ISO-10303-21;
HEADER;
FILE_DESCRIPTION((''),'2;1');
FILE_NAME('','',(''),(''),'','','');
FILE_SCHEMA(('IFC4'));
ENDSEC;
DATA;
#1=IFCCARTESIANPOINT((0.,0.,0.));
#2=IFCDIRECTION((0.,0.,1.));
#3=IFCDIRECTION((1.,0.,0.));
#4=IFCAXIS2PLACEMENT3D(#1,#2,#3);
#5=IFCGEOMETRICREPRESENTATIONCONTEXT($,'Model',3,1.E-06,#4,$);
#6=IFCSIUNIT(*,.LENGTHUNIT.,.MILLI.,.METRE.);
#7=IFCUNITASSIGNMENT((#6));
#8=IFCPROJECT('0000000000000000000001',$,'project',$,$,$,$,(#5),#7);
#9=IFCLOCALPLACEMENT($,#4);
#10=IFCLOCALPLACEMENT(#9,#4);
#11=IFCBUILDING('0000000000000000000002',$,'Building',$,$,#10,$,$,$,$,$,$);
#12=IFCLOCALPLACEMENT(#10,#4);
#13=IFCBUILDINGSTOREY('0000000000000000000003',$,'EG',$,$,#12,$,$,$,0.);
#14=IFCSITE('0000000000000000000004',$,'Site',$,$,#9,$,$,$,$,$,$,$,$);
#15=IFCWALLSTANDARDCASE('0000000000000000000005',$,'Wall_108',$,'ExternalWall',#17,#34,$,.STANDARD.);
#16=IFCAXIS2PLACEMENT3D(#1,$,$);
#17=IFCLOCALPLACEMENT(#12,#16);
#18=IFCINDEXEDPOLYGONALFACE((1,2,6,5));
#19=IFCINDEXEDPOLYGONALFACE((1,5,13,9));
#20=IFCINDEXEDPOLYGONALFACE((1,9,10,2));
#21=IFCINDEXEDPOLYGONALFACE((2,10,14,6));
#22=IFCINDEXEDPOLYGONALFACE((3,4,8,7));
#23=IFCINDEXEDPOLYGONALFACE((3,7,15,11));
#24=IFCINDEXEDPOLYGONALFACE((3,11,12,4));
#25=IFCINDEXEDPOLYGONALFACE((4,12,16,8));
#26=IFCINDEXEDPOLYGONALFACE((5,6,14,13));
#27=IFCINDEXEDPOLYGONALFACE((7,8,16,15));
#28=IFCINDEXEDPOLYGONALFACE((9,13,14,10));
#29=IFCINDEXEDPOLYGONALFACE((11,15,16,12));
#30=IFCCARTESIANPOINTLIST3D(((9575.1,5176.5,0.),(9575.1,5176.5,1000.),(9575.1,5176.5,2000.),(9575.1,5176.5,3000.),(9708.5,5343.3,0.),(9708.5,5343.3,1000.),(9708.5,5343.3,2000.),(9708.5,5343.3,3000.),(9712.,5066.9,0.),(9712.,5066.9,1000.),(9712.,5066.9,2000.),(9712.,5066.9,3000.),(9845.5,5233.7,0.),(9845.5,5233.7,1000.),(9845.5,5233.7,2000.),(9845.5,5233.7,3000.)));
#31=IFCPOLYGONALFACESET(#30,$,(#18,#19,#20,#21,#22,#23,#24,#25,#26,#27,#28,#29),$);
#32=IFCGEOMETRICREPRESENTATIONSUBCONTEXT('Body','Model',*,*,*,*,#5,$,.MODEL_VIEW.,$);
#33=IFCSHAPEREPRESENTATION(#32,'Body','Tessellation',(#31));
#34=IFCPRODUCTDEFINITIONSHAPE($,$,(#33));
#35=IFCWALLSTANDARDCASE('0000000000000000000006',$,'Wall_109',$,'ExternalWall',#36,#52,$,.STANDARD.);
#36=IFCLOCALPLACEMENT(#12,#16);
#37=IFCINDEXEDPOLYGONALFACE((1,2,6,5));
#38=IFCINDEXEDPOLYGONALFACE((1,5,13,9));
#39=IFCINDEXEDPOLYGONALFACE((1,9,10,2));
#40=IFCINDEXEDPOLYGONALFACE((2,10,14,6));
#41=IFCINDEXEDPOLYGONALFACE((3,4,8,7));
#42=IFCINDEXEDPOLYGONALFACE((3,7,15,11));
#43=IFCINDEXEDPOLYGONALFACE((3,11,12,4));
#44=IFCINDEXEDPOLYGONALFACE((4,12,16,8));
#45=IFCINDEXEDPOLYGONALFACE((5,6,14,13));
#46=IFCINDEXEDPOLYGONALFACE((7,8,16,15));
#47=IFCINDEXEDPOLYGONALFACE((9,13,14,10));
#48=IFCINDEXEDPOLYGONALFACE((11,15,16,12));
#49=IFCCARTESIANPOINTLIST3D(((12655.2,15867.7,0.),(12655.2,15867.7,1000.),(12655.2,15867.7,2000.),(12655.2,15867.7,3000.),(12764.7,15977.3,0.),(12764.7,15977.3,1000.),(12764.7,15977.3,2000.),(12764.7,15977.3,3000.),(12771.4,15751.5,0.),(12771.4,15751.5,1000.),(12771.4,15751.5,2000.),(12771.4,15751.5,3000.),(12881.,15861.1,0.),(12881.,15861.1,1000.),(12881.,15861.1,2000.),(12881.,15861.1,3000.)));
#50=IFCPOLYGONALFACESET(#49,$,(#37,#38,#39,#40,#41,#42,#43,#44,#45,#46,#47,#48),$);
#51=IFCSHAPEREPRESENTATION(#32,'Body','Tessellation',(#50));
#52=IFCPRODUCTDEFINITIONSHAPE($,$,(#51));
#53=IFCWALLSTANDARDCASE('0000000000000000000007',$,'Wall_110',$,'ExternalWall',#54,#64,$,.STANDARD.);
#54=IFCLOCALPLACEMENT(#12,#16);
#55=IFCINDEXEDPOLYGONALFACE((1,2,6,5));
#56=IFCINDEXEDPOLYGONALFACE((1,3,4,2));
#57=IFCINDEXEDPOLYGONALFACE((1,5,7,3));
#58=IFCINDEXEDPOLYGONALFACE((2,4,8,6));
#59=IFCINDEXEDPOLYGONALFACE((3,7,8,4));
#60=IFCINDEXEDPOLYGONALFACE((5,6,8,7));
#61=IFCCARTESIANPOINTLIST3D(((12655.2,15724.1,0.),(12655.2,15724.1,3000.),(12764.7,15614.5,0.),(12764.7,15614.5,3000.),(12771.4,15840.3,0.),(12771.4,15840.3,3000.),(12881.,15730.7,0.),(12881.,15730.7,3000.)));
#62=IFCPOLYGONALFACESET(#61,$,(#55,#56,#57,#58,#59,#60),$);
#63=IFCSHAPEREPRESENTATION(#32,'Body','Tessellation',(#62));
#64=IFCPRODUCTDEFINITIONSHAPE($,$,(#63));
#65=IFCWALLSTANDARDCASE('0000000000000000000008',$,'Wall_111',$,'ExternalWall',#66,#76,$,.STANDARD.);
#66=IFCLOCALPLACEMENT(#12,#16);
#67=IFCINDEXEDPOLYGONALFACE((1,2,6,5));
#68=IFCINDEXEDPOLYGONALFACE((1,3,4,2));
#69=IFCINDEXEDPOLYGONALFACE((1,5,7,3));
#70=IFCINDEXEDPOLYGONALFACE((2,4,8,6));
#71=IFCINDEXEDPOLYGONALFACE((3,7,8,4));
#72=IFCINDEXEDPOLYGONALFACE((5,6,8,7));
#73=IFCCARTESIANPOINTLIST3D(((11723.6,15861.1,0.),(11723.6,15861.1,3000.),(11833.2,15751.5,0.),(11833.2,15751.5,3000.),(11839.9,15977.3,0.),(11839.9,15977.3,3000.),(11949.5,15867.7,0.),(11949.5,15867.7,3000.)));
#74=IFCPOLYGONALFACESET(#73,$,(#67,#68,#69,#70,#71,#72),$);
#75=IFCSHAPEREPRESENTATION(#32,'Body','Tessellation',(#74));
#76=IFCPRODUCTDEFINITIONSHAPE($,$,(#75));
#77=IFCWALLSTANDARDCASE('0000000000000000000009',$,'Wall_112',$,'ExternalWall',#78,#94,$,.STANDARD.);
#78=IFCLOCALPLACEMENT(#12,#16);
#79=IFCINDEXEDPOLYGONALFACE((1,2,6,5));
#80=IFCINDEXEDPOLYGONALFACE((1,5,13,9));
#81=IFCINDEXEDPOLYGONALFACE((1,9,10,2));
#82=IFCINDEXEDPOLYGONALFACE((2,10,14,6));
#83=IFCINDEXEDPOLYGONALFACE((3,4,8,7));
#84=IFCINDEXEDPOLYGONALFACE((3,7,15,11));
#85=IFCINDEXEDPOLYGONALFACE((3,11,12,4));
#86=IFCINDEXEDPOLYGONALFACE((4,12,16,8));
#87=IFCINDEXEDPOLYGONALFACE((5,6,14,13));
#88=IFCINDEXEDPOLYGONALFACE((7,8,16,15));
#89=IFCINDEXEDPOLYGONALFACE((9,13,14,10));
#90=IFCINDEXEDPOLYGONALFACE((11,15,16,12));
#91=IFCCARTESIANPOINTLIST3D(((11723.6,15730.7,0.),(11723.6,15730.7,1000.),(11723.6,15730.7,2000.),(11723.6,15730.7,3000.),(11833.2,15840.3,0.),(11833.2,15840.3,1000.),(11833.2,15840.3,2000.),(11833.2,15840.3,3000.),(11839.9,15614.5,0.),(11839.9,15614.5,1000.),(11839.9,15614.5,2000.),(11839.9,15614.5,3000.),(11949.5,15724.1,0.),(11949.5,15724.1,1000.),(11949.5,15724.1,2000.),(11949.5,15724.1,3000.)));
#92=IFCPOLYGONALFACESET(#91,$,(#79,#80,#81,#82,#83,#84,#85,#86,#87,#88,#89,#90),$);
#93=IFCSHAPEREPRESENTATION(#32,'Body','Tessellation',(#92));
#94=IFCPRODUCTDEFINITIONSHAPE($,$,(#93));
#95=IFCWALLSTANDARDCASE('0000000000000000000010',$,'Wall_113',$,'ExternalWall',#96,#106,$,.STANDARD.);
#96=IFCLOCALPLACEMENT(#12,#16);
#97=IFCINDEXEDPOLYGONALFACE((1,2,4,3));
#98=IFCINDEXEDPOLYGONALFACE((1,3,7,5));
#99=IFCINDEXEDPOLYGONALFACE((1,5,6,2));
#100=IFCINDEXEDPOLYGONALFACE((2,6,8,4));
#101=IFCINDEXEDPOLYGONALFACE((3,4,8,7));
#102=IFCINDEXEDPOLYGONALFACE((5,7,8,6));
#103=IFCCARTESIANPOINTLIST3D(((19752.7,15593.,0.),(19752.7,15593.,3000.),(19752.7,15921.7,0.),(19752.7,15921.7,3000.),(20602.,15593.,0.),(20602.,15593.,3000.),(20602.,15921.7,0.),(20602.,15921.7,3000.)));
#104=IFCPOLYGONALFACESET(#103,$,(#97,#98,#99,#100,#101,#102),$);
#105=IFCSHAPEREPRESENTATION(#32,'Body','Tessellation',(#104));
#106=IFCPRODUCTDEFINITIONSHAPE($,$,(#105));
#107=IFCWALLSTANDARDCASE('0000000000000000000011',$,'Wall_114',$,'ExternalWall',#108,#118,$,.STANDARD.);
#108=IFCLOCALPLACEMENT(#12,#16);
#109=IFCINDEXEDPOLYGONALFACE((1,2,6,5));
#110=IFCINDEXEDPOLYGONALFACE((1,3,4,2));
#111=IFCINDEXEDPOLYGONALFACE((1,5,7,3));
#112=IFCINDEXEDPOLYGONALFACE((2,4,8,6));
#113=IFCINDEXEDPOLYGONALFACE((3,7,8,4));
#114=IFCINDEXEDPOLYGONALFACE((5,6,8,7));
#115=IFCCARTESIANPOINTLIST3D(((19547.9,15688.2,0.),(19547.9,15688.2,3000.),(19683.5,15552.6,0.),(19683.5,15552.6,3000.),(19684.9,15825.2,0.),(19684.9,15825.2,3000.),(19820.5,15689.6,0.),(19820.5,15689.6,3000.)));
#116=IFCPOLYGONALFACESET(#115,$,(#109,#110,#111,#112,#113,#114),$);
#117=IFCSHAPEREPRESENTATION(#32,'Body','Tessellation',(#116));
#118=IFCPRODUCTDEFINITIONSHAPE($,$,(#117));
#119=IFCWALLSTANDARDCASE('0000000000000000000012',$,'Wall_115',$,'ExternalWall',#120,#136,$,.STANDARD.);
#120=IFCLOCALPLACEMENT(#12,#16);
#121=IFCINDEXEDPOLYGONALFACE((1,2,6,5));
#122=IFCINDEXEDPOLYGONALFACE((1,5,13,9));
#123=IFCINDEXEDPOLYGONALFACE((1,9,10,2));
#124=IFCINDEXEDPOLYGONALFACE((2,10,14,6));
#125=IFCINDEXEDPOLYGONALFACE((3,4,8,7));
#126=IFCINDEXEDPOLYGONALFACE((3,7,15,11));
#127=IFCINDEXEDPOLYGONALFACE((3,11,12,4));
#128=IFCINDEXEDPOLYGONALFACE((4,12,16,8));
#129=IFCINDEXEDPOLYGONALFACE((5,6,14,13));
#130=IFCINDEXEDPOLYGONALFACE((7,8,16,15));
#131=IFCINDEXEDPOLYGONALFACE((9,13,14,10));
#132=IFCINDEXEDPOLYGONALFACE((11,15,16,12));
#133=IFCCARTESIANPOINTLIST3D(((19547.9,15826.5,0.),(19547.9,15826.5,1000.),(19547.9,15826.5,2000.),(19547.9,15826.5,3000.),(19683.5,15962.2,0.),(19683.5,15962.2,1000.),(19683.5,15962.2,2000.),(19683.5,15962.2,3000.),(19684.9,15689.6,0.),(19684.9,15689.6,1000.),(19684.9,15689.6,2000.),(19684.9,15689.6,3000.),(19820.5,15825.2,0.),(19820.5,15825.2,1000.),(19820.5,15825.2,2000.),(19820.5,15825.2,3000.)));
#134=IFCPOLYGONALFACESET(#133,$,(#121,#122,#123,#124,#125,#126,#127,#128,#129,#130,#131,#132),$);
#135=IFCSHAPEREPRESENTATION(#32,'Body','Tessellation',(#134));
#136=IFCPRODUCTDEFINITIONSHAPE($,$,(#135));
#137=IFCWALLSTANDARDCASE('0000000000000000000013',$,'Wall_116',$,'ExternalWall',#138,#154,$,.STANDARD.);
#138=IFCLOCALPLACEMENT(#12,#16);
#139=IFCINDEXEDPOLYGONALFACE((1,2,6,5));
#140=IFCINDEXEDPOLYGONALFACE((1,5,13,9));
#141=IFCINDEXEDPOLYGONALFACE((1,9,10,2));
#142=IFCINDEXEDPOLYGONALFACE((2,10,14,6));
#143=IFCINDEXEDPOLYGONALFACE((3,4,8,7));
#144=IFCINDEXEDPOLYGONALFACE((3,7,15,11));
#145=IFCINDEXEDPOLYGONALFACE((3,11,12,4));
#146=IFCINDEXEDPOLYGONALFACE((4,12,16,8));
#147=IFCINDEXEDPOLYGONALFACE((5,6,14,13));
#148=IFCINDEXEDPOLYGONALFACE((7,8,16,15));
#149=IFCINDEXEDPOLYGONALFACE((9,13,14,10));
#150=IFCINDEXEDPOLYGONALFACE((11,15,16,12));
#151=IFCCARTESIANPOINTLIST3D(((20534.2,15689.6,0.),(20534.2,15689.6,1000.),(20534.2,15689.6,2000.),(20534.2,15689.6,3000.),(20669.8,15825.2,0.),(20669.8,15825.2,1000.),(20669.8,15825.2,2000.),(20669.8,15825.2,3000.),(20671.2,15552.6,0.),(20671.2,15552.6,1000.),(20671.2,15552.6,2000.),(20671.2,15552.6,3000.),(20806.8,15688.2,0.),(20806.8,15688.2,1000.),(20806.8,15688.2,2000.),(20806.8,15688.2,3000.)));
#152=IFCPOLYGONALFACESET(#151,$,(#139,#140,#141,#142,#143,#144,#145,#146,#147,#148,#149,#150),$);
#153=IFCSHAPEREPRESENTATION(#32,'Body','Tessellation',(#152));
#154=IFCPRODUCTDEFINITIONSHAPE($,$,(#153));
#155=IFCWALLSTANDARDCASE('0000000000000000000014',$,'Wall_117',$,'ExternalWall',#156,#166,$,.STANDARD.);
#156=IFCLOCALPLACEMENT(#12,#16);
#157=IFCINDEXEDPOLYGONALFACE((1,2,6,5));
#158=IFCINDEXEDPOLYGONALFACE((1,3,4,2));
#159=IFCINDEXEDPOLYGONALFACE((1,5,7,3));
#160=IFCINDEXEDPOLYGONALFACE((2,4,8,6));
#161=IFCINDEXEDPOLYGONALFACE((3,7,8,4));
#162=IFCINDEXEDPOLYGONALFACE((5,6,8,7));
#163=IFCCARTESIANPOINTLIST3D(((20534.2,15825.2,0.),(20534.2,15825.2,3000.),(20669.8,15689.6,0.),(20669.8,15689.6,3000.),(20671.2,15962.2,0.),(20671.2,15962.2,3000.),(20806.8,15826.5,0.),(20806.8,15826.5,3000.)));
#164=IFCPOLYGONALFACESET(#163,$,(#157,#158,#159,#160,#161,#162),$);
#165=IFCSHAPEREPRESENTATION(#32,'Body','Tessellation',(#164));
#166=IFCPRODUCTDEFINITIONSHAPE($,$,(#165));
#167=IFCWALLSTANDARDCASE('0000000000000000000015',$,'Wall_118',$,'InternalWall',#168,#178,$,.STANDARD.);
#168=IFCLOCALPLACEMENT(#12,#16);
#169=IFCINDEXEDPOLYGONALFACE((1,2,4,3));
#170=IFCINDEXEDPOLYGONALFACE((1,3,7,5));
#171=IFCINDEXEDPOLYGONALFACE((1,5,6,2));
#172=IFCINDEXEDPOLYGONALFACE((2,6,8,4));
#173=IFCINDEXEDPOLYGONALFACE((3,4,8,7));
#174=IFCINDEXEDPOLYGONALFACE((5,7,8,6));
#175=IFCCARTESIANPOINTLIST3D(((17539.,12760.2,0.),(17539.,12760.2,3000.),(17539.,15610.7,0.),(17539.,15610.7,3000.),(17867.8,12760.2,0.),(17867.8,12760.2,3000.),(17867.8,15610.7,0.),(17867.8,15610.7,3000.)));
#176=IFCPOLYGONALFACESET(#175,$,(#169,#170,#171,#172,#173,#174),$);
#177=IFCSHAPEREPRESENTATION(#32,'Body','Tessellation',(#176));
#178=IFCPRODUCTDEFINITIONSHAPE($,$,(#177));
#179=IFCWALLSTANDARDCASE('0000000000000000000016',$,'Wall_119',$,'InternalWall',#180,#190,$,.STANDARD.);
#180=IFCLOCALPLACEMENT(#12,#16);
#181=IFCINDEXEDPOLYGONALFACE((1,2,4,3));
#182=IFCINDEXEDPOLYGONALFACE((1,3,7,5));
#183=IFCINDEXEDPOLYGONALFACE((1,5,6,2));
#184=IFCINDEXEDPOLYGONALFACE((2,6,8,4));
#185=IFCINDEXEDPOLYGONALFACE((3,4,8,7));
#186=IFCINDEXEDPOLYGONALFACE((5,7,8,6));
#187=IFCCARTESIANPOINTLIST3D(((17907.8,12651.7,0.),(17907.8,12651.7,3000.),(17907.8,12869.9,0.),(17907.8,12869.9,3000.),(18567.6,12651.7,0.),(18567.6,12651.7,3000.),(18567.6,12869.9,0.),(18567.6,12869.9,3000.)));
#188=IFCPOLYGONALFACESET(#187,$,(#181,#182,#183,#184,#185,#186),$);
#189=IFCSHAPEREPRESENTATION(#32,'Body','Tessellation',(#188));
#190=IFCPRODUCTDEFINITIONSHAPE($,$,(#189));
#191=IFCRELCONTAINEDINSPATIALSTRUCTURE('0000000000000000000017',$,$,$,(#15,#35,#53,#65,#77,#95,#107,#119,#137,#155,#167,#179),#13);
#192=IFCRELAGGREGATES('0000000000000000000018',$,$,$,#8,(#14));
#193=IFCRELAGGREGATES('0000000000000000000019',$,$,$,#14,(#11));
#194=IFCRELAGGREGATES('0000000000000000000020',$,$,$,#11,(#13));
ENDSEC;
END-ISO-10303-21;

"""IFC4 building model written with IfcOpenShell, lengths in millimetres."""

from ifc_helpers import new_model, si_unit, frame, origin_with_axes, place, context, subcontext, project, spatial, rectangle, extrude, element, save


model = new_model("IFC4")

# Units and contexts
model_context = context("Model", 3, precision=1e-06, world=origin_with_axes())
body_context = subcontext(model_context, "Body", "Model", "MODEL_VIEW")
ifc_project = project(units=[si_unit("LENGTHUNIT", "METRE", prefix="MILLI")], contexts=[model_context])

# Site, building, storey
site_placement = place(None, origin_with_axes())
site = spatial("IfcSite", under=ifc_project, at=site_placement, Name="Site")
building_placement = place(site_placement, origin_with_axes())
building = spatial("IfcBuilding", under=site, at=building_placement, Name="Building")
storey_placement = place(building_placement, origin_with_axes())
storey = spatial("IfcBuildingStorey", under=building, at=storey_placement, Name="EG", Elevation=0.0)

# Walls, openings
wall_1_placement = place(storey_placement, origin_with_axes())
wall_1 = element("IfcWallStandardCase", 1, at=wall_1_placement, inside=storey, Name="Wall_108", ObjectType="ExternalWall", PredefinedType="STANDARD", context=body_context, shape_type="SweptSolid", body=[
    extrude(rectangle(XDim=175.4, YDim=213.6), frame((9710.3, 5205.1, 0.0), z_axis=(0.0, 0.0, 1.0), x_axis=(0.780869, -0.624695, 0.0)), (0.0, 0.0, 1.0), 3000.0),
])
opening_1_placement = place(wall_1_placement, origin_with_axes())
element("IfcOpeningElement", 2, at=opening_1_placement, inside=storey, cuts=wall_1, context=body_context, shape_type="SweptSolid", body=[
    extrude(rectangle(XDim=600.0, YDim=213.6), frame((9736.6, 5184.1, 1000.0), z_axis=(0.0, 0.0, 1.0), x_axis=(0.780869, -0.624695, 0.0)), (0.0, 0.0, 1.0), 1000.0),
])
wall_2_placement = place(storey_placement, origin_with_axes())
wall_2 = element("IfcWallStandardCase", 3, at=wall_2_placement, inside=storey, Name="Wall_109", ObjectType="ExternalWall", PredefinedType="STANDARD", context=body_context, shape_type="SweptSolid", body=[
    extrude(rectangle(XDim=155.0, YDim=164.4), frame((12768.1, 15864.4, 0.0), z_axis=(0.0, 0.0, 1.0), x_axis=(0.707107, 0.707107, 0.0)), (0.0, 0.0, 1.0), 3000.0),
])
opening_2_placement = place(wall_2_placement, origin_with_axes())
element("IfcOpeningElement", 4, at=opening_2_placement, inside=storey, cuts=wall_2, context=body_context, shape_type="SweptSolid", body=[
    extrude(rectangle(XDim=600.0, YDim=164.4), frame((12768.1, 15864.4, 1000.0), z_axis=(0.0, 0.0, 1.0), x_axis=(0.707107, 0.707107, 0.0)), (0.0, 0.0, 1.0), 1000.0),
])

# Walls
wall_3_placement = place(storey_placement, origin_with_axes())
element("IfcWallStandardCase", 5, at=wall_3_placement, inside=storey, Name="Wall_110", ObjectType="ExternalWall", PredefinedType="STANDARD", context=body_context, shape_type="SweptSolid", body=[
    extrude(rectangle(XDim=155.0, YDim=164.4), frame((12768.1, 15727.4, 0.0), z_axis=(0.0, 0.0, 1.0), x_axis=(0.707107, -0.707107, 0.0)), (0.0, 0.0, 1.0), 3000.0),
])
wall_4_placement = place(storey_placement, origin_with_axes())
element("IfcWallStandardCase", 6, at=wall_4_placement, inside=storey, Name="Wall_111", ObjectType="ExternalWall", PredefinedType="STANDARD", context=body_context, shape_type="SweptSolid", body=[
    extrude(rectangle(XDim=155.0, YDim=164.4), frame((11836.6, 15864.4, 0.0), z_axis=(0.0, 0.0, 1.0), x_axis=(-0.707107, 0.707107, 0.0)), (0.0, 0.0, 1.0), 3000.0),
])

# Wall, opening
wall_5_placement = place(storey_placement, origin_with_axes())
wall_5 = element("IfcWallStandardCase", 7, at=wall_5_placement, inside=storey, Name="Wall_112", ObjectType="ExternalWall", PredefinedType="STANDARD", context=body_context, shape_type="SweptSolid", body=[
    extrude(rectangle(XDim=155.0, YDim=164.4), frame((11836.6, 15727.4, 0.0), z_axis=(0.0, 0.0, 1.0), x_axis=(-0.707107, -0.707107, 0.0)), (0.0, 0.0, 1.0), 3000.0),
])
opening_3_placement = place(wall_5_placement, origin_with_axes())
element("IfcOpeningElement", 8, at=opening_3_placement, inside=storey, cuts=wall_5, context=body_context, shape_type="SweptSolid", body=[
    extrude(rectangle(XDim=600.0, YDim=164.4), frame((11825.1, 15715.9, 1000.0), z_axis=(0.0, 0.0, 1.0), x_axis=(-0.707107, -0.707107, 0.0)), (0.0, 0.0, 1.0), 1000.0),
])

# Walls
wall_6_placement = place(storey_placement, origin_with_axes())
element("IfcWallStandardCase", 9, at=wall_6_placement, inside=storey, Name="Wall_113", ObjectType="ExternalWall", PredefinedType="STANDARD", context=body_context, shape_type="SweptSolid", body=[
    extrude(rectangle(XDim=849.3, YDim=328.8), frame((20177.3, 15757.4, 0.0), z_axis=(0.0, 0.0, 1.0), x_axis=(-1.0, 0.0, 0.0)), (0.0, 0.0, 1.0), 3000.0),
])
wall_7_placement = place(storey_placement, origin_with_axes())
element("IfcWallStandardCase", 10, at=wall_7_placement, inside=storey, Name="Wall_114", ObjectType="ExternalWall", PredefinedType="STANDARD", context=body_context, shape_type="SweptSolid", body=[
    extrude(rectangle(XDim=193.7, YDim=191.8), frame((19684.2, 15688.9, 0.0), z_axis=(0.0, 0.0, 1.0), x_axis=(-0.707107, -0.707107, 0.0)), (0.0, 0.0, 1.0), 3000.0),
])

# Walls, openings
wall_8_placement = place(storey_placement, origin_with_axes())
wall_8 = element("IfcWallStandardCase", 11, at=wall_8_placement, inside=storey, Name="Wall_115", ObjectType="ExternalWall", PredefinedType="STANDARD", context=body_context, shape_type="SweptSolid", body=[
    extrude(rectangle(XDim=193.7, YDim=191.8), frame((19684.2, 15825.9, 0.0), z_axis=(0.0, 0.0, 1.0), x_axis=(-0.707107, 0.707107, 0.0)), (0.0, 0.0, 1.0), 3000.0),
])
opening_4_placement = place(wall_8_placement, origin_with_axes())
element("IfcOpeningElement", 12, at=opening_4_placement, inside=storey, cuts=wall_8, context=body_context, shape_type="SweptSolid", body=[
    extrude(rectangle(XDim=600.0, YDim=191.8), frame((19677.6, 15832.4, 1000.0), z_axis=(0.0, 0.0, 1.0), x_axis=(-0.707107, 0.707107, 0.0)), (0.0, 0.0, 1.0), 1000.0),
])
wall_9_placement = place(storey_placement, origin_with_axes())
wall_9 = element("IfcWallStandardCase", 13, at=wall_9_placement, inside=storey, Name="Wall_116", ObjectType="ExternalWall", PredefinedType="STANDARD", context=body_context, shape_type="SweptSolid", body=[
    extrude(rectangle(XDim=193.7, YDim=191.8), frame((20670.5, 15688.9, 0.0), z_axis=(0.0, 0.0, 1.0), x_axis=(0.707107, -0.707107, 0.0)), (0.0, 0.0, 1.0), 3000.0),
])
opening_5_placement = place(wall_9_placement, origin_with_axes())
element("IfcOpeningElement", 14, at=opening_5_placement, inside=storey, cuts=wall_9, context=body_context, shape_type="SweptSolid", body=[
    extrude(rectangle(XDim=600.0, YDim=191.8), frame((20673.6, 15685.8, 1000.0), z_axis=(0.0, 0.0, 1.0), x_axis=(0.707107, -0.707107, 0.0)), (0.0, 0.0, 1.0), 1000.0),
])

# Walls
wall_10_placement = place(storey_placement, origin_with_axes())
element("IfcWallStandardCase", 15, at=wall_10_placement, inside=storey, Name="Wall_117", ObjectType="ExternalWall", PredefinedType="STANDARD", context=body_context, shape_type="SweptSolid", body=[
    extrude(rectangle(XDim=193.7, YDim=191.8), frame((20670.5, 15825.9, 0.0), z_axis=(0.0, 0.0, 1.0), x_axis=(0.707107, 0.707107, 0.0)), (0.0, 0.0, 1.0), 3000.0),
])
wall_11_placement = place(storey_placement, origin_with_axes())
element("IfcWallStandardCase", 16, at=wall_11_placement, inside=storey, Name="Wall_118", ObjectType="InternalWall", PredefinedType="STANDARD", context=body_context, shape_type="SweptSolid", body=[
    extrude(rectangle(XDim=2850.5, YDim=328.8), frame((17703.4, 14185.4, 0.0), z_axis=(0.0, 0.0, 1.0), x_axis=(0.0, -1.0, 0.0)), (0.0, 0.0, 1.0), 3000.0),
])
wall_12_placement = place(storey_placement, origin_with_axes())
element("IfcWallStandardCase", 17, at=wall_12_placement, inside=storey, Name="Wall_119", ObjectType="InternalWall", PredefinedType="STANDARD", context=body_context, shape_type="SweptSolid", body=[
    extrude(rectangle(XDim=659.8, YDim=218.1), frame((18237.7, 12760.8, 0.0), z_axis=(0.0, 0.0, 1.0), x_axis=(-1.0, 0.0, 0.0)), (0.0, 0.0, 1.0), 3000.0),
])

save(model, "model.ifc")
